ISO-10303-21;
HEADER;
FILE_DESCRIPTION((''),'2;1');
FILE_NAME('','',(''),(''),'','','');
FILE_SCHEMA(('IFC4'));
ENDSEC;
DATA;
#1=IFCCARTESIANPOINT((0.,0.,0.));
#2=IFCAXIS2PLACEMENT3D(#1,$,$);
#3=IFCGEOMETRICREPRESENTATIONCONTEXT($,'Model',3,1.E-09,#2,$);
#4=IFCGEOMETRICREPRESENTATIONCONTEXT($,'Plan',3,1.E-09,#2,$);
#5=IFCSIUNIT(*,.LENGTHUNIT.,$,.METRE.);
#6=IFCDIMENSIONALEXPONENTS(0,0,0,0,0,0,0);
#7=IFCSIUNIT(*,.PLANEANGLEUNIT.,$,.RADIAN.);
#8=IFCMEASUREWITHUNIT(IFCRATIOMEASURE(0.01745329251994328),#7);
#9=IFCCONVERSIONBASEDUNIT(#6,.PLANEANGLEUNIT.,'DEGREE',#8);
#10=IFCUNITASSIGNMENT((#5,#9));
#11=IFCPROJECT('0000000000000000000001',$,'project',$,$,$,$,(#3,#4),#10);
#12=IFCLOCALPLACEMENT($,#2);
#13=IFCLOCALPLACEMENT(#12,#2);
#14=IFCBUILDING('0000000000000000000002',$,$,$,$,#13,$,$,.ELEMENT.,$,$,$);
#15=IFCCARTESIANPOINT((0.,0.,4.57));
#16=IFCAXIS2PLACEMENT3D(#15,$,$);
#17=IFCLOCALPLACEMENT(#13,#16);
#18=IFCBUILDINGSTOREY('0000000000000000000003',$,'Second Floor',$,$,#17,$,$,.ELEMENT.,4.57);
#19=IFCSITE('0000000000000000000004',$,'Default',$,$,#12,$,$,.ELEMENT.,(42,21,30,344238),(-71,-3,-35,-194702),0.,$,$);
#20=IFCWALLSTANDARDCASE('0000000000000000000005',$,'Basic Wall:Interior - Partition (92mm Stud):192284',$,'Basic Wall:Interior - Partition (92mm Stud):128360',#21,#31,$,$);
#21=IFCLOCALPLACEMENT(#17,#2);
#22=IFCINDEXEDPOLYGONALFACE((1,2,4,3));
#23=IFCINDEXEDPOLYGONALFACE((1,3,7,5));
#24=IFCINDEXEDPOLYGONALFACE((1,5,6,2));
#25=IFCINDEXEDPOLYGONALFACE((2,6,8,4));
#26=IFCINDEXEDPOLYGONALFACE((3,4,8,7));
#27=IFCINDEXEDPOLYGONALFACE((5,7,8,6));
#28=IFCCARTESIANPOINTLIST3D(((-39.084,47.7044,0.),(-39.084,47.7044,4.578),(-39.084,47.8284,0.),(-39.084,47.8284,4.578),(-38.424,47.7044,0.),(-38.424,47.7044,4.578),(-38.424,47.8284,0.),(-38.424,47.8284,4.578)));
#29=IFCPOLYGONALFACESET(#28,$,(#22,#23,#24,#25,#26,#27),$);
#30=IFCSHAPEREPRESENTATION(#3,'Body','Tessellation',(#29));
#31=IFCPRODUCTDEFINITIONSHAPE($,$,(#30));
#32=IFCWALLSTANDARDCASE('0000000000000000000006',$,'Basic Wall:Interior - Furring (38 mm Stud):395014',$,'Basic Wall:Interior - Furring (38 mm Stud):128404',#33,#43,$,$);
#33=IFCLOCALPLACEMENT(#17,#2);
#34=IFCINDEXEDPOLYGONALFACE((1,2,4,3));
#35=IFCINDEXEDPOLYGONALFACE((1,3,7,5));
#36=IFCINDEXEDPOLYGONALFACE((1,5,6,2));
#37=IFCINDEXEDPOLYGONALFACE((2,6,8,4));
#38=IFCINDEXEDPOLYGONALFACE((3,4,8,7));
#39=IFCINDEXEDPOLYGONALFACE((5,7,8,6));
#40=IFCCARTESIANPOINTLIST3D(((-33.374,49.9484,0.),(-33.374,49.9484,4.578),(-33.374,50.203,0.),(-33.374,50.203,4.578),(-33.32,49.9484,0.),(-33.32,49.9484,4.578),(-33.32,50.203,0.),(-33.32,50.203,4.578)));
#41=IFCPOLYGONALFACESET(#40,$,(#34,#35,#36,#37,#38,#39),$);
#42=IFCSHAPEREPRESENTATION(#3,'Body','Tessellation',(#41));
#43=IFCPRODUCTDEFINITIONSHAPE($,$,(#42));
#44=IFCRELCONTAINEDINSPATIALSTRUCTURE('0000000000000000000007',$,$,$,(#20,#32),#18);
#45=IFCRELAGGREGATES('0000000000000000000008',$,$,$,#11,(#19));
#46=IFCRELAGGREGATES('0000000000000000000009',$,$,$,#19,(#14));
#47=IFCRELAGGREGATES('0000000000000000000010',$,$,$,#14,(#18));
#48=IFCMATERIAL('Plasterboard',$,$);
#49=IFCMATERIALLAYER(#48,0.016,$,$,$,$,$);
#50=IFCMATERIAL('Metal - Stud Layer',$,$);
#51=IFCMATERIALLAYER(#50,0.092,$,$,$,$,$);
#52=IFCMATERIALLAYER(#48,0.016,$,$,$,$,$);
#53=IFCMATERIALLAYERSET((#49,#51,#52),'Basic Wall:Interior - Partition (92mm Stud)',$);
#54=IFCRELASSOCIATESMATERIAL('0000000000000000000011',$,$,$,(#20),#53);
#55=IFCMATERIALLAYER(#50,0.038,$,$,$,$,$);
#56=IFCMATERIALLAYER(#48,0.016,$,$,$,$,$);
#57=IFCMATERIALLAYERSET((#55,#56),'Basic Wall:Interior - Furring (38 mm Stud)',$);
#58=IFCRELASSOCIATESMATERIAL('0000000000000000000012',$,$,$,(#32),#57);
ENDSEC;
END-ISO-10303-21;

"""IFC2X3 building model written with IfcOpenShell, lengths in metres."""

from ifc_helpers import new_model, entity, si_unit, converted_unit, frame, frame_2d, origin, place, context, project, spatial, rectangle, extrude, material, layer, layer_set, layer_usage, element, save


model = new_model("IFC2X3")

# Units and contexts
model_context = context("Model", 3, precision=1e-09, world=origin())
plan_context = context("Plan", 3, precision=1e-09, world=origin())
ifc_project = project(units=[si_unit("LENGTHUNIT", "METRE"), converted_unit("PLANEANGLEUNIT", "DEGREE", entity("IfcRatioMeasure", 0.01745329251994328), si_unit("PLANEANGLEUNIT", "RADIAN"), dimensions=[0, 0, 0, 0, 0, 0, 0])], contexts=[model_context, plan_context])

# Site, building, storey
site_placement = place(None, origin())
site = spatial("IfcSite", under=ifc_project, at=site_placement, Name="Default", CompositionType="ELEMENT", RefLatitude=(42, 21, 30, 344238), RefLongitude=(-71, -3, -35, -194702), RefElevation=0.0)
building_placement = place(site_placement, origin())
building = spatial("IfcBuilding", under=site, at=building_placement, CompositionType="ELEMENT")
storey_placement = place(building_placement, frame((0.0, 0.0, 4.57)))
storey = spatial("IfcBuildingStorey", under=building, at=storey_placement, Name="Second Floor", CompositionType="ELEMENT", Elevation=4.57)

# Shared definitions
ifc_material_1 = material(Name="Plasterboard")
ifc_layer_1 = layer(ifc_material_1, 0.016)
ifc_material_2 = material(Name="Metal - Stud Layer")
ifc_layer_2 = layer(ifc_material_2, 0.092)
ifc_layer_3 = layer(ifc_material_1, 0.016)
ifc_layer_set_1 = layer_set([ifc_layer_1, ifc_layer_2, ifc_layer_3], Name="Basic Wall:Interior - Partition (92mm Stud)")
ifc_layer_usage_1 = layer_usage(ifc_layer_set_1, "AXIS2", "NEGATIVE", 0.062)

# Shared definitions
ifc_layer_4 = layer(ifc_material_2, 0.038)
ifc_layer_5 = layer(ifc_material_1, 0.016)
ifc_layer_set_2 = layer_set([ifc_layer_4, ifc_layer_5], Name="Basic Wall:Interior - Furring (38 mm Stud)")
ifc_layer_usage_2 = layer_usage(ifc_layer_set_2, "AXIS2", "NEGATIVE", 0.027)

# Walls
wall_1_placement = place(storey_placement, frame((-38.424, 47.7664, 0.0), z_axis=(0.0, 0.0, 1.0), x_axis=(-1.0, 0.0, 0.0)))
element("IfcWallStandardCase", 1, at=wall_1_placement, inside=storey, material=ifc_layer_usage_1, Name="Basic Wall:Interior - Partition (92mm Stud):192284", ObjectType="Basic Wall:Interior - Partition (92mm Stud):128360", context=model_context, shape_type="SweptSolid", body=[
    extrude(rectangle(XDim=0.66, YDim=0.124, at=frame_2d((0.33, 0.0), x_axis=(-1.0, 0.0))), origin(), (0.0, 0.0, 1.0), 4.578),
])
wall_2_placement = place(storey_placement, frame((-33.347, 49.9484, 0.0), z_axis=(0.0, 0.0, 1.0), x_axis=(0.0, 1.0, 0.0)))
element("IfcWallStandardCase", 2, at=wall_2_placement, inside=storey, material=ifc_layer_usage_2, Name="Basic Wall:Interior - Furring (38 mm Stud):395014", ObjectType="Basic Wall:Interior - Furring (38 mm Stud):128404", context=model_context, shape_type="SweptSolid", body=[
    extrude(rectangle(XDim=0.2546, YDim=0.054, at=frame_2d((0.1273, 0.0), x_axis=(-1.0, 0.0))), origin(), (0.0, 0.0, 1.0), 4.578),
])

save(model, "model.ifc")
